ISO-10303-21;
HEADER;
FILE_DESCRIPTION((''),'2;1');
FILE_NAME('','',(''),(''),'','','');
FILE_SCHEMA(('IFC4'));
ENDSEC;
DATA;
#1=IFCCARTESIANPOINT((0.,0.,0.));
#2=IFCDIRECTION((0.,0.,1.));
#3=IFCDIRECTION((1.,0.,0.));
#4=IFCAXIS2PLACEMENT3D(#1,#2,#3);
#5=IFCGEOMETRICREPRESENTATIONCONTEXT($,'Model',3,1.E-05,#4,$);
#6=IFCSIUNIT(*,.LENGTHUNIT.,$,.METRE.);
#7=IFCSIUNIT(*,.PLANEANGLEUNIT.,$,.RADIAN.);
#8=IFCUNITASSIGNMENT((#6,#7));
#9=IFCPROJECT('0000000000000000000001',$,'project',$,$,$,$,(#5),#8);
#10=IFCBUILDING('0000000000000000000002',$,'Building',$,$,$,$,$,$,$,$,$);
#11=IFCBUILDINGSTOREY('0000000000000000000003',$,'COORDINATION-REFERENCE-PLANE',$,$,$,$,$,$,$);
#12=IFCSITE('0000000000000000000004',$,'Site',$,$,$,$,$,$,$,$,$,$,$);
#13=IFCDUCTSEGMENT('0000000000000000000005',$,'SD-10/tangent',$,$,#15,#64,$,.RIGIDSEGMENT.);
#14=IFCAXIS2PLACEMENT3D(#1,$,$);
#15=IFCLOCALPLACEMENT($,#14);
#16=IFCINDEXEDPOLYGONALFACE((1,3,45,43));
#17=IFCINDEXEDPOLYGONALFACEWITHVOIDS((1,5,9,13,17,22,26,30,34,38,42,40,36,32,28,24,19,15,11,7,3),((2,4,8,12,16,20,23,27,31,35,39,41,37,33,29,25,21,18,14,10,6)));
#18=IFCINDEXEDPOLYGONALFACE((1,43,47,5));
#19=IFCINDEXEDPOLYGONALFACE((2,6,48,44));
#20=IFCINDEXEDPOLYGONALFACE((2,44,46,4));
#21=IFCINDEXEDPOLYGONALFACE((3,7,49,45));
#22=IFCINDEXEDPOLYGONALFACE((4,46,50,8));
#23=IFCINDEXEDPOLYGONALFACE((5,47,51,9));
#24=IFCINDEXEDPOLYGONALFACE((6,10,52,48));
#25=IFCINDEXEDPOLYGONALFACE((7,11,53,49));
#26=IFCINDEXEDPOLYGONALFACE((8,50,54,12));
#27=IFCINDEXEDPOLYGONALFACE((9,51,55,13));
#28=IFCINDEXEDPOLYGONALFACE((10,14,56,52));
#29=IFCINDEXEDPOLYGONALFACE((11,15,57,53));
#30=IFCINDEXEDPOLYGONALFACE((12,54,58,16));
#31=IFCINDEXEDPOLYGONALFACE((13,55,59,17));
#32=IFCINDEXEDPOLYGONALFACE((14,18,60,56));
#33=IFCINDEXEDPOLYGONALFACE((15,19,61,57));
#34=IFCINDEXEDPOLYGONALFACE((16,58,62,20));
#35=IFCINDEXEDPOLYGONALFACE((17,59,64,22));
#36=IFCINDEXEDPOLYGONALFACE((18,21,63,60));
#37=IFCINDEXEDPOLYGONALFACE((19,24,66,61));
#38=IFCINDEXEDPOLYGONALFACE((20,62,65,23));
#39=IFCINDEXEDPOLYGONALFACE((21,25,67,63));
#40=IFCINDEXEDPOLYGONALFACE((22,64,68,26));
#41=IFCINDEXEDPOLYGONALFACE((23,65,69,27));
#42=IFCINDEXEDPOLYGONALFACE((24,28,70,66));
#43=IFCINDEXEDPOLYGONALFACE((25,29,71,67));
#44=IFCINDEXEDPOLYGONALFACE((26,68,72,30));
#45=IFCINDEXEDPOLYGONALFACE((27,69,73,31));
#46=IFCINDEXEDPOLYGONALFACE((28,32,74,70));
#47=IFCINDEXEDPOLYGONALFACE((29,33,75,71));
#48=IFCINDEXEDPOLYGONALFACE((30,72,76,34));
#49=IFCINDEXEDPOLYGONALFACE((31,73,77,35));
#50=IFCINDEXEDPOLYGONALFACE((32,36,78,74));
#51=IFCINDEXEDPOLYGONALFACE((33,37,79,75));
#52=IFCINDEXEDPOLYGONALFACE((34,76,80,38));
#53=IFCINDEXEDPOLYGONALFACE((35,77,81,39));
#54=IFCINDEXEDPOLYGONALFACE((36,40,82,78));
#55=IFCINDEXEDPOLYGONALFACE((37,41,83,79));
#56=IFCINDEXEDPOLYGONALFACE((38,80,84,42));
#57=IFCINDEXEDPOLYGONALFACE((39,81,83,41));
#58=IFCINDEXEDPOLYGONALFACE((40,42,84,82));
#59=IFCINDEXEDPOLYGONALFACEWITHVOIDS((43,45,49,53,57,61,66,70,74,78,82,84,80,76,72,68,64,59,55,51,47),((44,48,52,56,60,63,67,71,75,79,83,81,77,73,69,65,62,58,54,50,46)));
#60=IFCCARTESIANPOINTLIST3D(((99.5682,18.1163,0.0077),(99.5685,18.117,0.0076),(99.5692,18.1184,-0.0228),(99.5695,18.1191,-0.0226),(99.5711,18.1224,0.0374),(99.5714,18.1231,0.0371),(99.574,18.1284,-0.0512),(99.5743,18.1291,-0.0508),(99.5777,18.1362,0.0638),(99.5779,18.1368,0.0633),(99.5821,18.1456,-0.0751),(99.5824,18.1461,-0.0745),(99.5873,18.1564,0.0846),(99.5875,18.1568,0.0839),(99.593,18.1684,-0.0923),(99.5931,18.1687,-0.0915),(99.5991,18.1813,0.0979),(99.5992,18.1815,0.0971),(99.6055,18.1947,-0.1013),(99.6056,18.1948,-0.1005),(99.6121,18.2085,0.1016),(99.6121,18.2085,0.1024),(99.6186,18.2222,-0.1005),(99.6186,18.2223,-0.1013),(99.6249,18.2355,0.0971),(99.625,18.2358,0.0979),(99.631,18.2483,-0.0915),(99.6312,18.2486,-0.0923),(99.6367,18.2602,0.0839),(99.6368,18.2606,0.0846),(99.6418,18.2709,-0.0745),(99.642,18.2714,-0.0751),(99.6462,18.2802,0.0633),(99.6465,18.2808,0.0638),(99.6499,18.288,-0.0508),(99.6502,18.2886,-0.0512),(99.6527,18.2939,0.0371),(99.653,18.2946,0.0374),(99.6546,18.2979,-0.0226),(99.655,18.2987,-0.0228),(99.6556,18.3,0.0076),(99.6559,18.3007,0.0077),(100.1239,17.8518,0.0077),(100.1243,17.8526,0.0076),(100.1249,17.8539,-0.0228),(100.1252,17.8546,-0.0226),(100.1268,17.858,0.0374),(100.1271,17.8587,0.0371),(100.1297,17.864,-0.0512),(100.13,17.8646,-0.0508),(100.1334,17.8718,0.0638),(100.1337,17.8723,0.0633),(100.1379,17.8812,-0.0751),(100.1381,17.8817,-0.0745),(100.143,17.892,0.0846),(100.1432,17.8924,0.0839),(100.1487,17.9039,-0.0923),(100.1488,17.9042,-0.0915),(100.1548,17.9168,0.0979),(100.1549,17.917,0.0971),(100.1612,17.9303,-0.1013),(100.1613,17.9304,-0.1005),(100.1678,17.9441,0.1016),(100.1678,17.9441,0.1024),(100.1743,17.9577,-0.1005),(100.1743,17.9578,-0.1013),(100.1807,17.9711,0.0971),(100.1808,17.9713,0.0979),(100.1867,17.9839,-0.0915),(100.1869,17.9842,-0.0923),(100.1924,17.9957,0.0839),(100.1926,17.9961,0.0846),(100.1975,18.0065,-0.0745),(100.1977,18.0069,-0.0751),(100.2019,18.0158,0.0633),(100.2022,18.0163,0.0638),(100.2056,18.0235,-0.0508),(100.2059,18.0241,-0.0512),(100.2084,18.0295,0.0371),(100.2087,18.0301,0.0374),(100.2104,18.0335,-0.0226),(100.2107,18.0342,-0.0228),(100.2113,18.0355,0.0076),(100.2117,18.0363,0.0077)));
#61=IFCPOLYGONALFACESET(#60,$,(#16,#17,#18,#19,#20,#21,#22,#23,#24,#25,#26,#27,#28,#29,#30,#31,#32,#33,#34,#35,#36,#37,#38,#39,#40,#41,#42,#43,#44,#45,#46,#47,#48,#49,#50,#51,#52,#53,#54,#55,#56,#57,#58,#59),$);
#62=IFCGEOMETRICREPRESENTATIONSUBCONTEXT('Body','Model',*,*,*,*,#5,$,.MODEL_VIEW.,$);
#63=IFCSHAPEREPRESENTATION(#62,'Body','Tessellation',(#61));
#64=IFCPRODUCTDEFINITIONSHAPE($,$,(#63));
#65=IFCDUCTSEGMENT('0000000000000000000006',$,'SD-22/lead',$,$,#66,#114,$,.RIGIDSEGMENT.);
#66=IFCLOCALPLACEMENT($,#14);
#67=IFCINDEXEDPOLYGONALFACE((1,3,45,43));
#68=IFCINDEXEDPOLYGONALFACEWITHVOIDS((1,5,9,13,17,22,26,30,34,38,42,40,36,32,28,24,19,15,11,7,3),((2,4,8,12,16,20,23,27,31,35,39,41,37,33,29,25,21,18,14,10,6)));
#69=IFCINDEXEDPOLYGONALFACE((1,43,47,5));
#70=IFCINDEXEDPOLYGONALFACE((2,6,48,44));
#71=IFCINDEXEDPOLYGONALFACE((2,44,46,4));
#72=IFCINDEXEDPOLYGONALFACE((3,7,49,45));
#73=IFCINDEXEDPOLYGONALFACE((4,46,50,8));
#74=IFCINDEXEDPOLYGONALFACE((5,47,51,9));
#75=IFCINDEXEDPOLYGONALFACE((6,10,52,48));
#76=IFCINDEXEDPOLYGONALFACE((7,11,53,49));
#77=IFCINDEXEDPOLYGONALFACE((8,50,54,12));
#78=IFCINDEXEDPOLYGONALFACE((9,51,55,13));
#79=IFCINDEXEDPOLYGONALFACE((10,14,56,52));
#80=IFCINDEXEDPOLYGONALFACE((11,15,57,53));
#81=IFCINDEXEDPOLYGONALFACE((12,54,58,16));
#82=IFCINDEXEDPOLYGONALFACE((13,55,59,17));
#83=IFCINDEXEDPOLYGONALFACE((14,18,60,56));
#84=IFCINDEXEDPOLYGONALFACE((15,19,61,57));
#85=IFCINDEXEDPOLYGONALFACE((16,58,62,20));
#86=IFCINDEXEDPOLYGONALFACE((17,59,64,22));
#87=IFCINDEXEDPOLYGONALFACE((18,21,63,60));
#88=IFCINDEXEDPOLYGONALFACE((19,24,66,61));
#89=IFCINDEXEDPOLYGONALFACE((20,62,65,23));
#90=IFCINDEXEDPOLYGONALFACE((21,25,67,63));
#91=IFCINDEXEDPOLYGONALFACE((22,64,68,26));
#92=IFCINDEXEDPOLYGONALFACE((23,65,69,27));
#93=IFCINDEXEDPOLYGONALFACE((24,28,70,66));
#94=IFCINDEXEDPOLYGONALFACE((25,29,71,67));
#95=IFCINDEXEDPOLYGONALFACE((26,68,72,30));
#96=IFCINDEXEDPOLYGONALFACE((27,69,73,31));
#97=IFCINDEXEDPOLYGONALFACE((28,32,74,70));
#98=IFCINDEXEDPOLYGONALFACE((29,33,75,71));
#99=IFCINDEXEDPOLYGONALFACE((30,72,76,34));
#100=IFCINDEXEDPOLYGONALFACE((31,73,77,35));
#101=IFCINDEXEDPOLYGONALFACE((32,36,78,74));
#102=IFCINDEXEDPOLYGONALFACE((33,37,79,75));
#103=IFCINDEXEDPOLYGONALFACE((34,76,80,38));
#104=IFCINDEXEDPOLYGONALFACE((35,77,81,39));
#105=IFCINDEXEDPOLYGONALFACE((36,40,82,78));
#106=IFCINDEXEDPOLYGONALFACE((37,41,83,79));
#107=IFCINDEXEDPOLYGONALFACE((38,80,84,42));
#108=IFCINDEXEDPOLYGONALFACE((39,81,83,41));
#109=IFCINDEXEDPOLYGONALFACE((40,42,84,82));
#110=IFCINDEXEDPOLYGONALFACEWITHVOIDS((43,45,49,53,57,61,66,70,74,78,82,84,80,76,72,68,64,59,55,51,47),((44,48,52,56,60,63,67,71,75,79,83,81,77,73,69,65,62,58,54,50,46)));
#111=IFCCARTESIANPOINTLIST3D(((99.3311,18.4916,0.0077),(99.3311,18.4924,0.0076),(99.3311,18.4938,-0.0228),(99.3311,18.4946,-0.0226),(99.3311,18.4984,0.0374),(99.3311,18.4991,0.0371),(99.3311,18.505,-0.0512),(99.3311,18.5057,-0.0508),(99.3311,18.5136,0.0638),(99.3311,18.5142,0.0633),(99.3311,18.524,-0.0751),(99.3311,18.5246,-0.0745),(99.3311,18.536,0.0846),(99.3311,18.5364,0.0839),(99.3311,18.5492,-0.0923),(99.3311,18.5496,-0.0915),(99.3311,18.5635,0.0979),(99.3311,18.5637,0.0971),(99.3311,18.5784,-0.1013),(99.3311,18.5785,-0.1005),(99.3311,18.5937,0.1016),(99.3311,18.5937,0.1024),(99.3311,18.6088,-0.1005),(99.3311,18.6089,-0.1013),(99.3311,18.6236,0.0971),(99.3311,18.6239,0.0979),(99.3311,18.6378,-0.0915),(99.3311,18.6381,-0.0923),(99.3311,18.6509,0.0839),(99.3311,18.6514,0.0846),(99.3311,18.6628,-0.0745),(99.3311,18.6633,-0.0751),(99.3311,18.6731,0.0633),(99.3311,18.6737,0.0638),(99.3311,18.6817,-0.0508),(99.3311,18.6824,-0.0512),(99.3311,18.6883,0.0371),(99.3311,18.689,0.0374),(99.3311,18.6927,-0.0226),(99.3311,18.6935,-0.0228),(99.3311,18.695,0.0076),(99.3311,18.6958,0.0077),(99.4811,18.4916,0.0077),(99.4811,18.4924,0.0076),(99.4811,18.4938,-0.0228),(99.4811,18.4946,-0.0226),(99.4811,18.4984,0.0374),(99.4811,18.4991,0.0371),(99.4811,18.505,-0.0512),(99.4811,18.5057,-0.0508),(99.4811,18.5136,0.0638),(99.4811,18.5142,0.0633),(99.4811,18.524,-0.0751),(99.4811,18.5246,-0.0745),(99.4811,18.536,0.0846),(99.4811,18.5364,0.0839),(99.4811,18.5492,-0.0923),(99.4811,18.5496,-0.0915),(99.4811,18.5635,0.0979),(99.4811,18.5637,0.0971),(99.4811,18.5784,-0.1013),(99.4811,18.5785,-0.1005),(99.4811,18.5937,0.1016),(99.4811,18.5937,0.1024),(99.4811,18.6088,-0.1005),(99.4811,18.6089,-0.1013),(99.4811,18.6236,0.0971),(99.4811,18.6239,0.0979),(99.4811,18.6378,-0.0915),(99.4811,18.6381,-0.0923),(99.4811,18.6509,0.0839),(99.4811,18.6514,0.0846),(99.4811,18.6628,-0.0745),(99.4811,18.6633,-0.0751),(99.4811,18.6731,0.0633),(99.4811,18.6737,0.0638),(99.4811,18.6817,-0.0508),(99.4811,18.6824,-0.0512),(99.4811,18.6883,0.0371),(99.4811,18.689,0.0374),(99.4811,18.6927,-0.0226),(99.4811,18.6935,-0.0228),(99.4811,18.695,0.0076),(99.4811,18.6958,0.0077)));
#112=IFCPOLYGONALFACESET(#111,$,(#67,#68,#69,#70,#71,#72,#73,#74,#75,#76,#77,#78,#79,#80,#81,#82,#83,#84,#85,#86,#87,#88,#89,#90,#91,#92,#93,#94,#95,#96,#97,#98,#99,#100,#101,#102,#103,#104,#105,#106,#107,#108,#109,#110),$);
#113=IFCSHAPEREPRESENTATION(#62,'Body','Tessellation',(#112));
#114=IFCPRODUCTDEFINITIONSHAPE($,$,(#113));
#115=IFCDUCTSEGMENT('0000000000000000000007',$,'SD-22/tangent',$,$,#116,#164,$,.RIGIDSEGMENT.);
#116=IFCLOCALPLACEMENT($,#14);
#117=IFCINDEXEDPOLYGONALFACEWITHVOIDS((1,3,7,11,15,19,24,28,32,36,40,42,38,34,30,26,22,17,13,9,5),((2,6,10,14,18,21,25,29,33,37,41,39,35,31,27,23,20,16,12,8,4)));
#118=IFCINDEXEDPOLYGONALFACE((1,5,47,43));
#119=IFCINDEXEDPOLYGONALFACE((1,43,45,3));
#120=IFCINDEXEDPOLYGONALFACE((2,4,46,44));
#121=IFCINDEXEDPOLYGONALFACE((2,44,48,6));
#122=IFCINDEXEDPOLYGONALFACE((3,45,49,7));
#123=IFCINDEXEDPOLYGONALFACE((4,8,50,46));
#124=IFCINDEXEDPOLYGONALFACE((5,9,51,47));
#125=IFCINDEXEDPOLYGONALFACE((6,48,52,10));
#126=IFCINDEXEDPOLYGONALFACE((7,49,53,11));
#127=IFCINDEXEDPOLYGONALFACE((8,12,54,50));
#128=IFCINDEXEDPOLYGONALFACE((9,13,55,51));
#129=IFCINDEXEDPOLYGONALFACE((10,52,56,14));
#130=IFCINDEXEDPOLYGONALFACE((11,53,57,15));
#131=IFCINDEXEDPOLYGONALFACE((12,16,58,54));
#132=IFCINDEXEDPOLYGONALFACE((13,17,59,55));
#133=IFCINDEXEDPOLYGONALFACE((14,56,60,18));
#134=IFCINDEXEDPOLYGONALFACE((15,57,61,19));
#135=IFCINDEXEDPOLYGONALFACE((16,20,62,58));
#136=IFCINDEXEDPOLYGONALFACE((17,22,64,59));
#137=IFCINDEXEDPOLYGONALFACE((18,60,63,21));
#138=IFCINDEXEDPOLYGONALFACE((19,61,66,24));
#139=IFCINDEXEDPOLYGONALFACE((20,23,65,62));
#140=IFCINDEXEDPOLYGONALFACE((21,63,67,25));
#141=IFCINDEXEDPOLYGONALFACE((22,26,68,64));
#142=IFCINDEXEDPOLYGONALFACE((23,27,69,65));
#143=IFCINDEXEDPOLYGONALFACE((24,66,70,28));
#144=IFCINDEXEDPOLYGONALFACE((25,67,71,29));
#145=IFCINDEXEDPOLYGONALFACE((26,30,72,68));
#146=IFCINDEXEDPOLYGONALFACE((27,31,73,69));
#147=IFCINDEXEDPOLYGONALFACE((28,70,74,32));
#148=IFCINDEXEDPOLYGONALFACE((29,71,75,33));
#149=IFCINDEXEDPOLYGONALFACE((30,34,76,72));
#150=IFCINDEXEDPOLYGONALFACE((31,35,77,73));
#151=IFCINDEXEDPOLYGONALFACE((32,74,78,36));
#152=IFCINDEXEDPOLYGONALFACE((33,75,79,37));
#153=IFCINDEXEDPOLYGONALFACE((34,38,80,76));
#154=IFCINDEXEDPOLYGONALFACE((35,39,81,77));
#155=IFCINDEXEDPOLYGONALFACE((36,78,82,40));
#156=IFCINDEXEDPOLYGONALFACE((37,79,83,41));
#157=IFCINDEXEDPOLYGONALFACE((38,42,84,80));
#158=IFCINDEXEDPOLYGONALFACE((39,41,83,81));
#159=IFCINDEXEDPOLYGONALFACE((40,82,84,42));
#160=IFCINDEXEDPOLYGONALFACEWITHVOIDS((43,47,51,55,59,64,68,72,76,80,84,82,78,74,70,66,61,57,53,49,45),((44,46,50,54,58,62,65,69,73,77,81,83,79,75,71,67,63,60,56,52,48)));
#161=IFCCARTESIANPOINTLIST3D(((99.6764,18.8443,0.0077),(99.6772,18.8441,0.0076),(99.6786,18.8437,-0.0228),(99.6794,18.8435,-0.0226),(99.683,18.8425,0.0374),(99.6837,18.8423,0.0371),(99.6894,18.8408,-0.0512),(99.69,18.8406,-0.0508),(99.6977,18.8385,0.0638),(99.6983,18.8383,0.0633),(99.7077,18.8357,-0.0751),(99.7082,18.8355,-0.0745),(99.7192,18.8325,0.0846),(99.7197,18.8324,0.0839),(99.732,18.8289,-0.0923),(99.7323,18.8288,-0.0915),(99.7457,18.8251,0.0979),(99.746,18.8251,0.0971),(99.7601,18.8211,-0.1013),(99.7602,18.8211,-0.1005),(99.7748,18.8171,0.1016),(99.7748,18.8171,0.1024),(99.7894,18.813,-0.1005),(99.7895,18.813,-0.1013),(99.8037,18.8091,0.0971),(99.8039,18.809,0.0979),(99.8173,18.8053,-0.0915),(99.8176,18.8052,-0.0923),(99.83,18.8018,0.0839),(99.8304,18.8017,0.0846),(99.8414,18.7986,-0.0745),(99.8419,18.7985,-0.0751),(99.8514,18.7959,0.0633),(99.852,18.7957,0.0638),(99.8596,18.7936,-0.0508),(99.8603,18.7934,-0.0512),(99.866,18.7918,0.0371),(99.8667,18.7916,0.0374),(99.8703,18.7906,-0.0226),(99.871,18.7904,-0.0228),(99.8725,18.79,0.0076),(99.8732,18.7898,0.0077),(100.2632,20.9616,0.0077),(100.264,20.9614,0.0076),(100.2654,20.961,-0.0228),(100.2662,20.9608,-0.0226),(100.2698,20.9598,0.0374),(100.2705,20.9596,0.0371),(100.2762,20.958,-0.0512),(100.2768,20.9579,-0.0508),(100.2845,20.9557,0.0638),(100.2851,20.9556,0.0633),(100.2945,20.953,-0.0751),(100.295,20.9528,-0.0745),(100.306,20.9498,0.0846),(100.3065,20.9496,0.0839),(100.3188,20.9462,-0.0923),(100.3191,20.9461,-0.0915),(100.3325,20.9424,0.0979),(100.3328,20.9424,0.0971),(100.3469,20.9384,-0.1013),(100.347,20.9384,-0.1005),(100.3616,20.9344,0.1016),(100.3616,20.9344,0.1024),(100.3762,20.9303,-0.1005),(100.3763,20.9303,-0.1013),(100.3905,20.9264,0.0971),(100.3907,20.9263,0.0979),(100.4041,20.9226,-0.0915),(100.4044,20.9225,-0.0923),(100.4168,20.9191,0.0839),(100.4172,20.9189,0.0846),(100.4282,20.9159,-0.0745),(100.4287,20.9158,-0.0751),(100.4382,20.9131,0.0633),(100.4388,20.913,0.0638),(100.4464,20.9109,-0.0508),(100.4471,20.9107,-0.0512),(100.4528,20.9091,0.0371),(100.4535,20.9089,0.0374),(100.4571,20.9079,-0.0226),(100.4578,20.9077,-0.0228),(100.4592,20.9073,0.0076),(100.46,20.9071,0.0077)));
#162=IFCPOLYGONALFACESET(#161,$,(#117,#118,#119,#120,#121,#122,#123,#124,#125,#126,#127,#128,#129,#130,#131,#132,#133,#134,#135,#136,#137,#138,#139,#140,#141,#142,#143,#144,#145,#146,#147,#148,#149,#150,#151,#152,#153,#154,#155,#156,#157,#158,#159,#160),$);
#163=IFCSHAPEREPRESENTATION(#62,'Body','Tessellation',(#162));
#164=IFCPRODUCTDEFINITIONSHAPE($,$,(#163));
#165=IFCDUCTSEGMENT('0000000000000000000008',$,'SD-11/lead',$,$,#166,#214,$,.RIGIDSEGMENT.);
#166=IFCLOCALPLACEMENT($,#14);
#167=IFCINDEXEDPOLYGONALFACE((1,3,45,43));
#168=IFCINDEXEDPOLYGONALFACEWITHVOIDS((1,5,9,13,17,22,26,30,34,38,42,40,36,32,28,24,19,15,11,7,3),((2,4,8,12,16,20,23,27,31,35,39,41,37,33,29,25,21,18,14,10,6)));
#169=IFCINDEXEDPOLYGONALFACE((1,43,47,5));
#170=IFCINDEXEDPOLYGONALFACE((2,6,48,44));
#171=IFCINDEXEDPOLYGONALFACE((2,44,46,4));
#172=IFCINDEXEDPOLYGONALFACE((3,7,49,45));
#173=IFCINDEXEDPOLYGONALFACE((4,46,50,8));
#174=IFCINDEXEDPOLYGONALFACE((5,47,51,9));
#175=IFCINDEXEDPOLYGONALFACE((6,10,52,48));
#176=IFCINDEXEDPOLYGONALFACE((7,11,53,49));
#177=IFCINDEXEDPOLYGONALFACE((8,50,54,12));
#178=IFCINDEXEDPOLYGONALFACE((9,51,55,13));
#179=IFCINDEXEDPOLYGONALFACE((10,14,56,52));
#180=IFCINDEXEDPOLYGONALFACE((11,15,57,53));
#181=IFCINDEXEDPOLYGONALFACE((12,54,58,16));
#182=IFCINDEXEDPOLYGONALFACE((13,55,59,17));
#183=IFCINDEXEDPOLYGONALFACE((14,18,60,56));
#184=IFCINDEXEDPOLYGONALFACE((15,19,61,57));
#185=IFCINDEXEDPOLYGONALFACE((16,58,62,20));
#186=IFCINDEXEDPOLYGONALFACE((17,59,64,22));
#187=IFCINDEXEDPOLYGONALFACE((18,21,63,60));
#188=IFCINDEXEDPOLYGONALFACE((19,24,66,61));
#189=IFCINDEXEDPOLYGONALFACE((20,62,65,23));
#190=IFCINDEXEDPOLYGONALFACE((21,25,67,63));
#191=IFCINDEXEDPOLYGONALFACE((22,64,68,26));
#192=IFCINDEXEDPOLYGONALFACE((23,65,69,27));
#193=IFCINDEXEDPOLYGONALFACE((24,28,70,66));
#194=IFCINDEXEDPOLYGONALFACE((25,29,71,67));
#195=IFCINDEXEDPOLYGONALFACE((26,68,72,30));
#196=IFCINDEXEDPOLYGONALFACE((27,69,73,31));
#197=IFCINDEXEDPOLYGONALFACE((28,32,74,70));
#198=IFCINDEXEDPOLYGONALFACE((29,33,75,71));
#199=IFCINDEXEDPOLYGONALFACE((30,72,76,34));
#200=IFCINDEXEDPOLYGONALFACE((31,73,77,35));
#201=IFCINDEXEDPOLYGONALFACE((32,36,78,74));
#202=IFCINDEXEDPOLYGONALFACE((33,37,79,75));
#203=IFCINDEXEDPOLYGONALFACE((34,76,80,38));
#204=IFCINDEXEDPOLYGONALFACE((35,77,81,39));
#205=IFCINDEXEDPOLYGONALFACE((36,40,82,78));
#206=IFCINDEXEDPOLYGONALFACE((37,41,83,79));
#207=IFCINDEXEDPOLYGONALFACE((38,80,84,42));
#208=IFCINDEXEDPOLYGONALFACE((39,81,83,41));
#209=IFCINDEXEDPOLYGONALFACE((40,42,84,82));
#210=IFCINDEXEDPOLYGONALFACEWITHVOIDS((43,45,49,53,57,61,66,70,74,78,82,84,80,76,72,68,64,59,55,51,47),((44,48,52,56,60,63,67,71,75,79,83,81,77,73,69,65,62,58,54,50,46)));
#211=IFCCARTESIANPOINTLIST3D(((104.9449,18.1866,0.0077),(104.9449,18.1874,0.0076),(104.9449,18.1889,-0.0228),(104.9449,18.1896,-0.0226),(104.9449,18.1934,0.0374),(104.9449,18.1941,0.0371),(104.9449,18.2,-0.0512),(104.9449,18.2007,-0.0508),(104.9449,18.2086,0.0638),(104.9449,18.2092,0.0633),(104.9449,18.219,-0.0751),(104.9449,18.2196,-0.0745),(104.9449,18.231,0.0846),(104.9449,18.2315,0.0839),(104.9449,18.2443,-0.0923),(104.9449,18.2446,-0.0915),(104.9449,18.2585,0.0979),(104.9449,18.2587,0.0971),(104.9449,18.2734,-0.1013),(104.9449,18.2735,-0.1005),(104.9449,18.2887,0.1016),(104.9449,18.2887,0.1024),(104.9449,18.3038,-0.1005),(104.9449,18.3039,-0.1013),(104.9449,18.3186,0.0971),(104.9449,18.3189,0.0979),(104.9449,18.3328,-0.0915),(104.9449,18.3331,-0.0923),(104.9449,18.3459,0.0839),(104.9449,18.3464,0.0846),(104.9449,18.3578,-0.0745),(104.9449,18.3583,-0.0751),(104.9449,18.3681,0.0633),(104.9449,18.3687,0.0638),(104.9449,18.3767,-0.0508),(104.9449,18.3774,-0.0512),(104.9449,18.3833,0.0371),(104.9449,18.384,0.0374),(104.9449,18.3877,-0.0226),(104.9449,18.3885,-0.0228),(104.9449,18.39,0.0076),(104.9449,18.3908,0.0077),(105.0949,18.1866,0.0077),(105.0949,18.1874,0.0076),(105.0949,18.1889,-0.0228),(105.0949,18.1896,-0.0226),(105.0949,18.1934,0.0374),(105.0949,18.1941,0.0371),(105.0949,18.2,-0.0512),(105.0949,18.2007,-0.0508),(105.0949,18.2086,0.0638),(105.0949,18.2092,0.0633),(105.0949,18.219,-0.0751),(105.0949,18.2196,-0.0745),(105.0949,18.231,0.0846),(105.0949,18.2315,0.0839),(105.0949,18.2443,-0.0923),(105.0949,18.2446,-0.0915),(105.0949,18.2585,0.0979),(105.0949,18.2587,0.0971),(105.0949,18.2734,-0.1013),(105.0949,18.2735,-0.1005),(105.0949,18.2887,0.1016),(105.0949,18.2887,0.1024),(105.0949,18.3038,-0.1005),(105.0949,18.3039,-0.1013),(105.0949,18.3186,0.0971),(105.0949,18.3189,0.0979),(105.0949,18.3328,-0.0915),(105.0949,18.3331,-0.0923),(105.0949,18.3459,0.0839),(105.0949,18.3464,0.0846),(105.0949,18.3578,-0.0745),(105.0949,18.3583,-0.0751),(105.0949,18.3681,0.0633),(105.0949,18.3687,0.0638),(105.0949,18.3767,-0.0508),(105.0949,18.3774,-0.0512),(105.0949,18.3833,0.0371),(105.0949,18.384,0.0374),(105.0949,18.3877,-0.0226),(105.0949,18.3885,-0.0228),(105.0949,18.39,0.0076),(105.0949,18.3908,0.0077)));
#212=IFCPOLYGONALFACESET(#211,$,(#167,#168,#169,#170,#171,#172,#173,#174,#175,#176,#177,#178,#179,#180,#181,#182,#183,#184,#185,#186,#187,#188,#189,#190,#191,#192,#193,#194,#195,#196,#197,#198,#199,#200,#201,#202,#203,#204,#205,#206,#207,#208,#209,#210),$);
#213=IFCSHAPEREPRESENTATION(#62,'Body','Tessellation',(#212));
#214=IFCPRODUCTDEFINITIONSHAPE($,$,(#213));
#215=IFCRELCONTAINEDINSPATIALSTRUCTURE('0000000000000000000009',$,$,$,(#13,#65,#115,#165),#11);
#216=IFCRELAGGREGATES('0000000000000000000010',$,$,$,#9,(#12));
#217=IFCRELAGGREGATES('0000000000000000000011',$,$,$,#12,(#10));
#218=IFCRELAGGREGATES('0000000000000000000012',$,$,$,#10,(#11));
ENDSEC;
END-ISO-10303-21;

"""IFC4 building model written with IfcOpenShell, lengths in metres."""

from ifc_helpers import new_model, si_unit, frame, origin_with_axes, place, context, subcontext, project, spatial, hollow_circle, extrude, element, save


model = new_model("IFC4")

# Units and contexts
model_context = context("Model", 3, precision=1e-05, world=origin_with_axes())
body_context_1 = subcontext(model_context, "Body", "Model", "MODEL_VIEW")
ifc_project = project(units=[si_unit("LENGTHUNIT", "METRE"), si_unit("PLANEANGLEUNIT", "RADIAN")], contexts=[model_context])

# Site, building, storey
site = spatial("IfcSite", under=ifc_project, Name="Site")
building = spatial("IfcBuilding", under=site, Name="Building")
storey = spatial("IfcBuildingStorey", under=building, Name="COORDINATION-REFERENCE-PLANE")

# Duct segment
duct_segment_1_placement = place(None, frame((99.6121, 18.2085, 0.0), z_axis=(0.902975, -0.429693, 0.0), x_axis=(0.0, 0.0, 1.0)))
element("IfcDuctSegment", 1, at=duct_segment_1_placement, inside=storey, Name="SD-10/tangent", PredefinedType="RIGIDSEGMENT", context=body_context_1, shape_type="SweptSolid", body=[
    extrude(hollow_circle(Radius=0.1024, WallThickness=0.0008), origin_with_axes(), (0.0, 0.0, 1.0), 0.6154),
])

# Duct segment
duct_segment_2_placement = place(None, frame((99.3311, 18.5937, 0.0), z_axis=(1.0, 0.0, 0.0), x_axis=(0.0, 0.0, 1.0)))
element("IfcDuctSegment", 2, at=duct_segment_2_placement, inside=storey, Name="SD-22/lead", PredefinedType="RIGIDSEGMENT", context=body_context_1, shape_type="SweptSolid", body=[
    extrude(hollow_circle(Radius=0.1024, WallThickness=0.0008), origin_with_axes(), (0.0, 0.0, 1.0), 0.15),
])

# Duct segment
duct_segment_3_placement = place(None, frame((99.7748, 18.8171, 0.0), z_axis=(0.267077, 0.963675, 0.0), x_axis=(0.0, 0.0, 1.0)))
element("IfcDuctSegment", 3, at=duct_segment_3_placement, inside=storey, Name="SD-22/tangent", PredefinedType="RIGIDSEGMENT", context=body_context_1, shape_type="SweptSolid", body=[
    extrude(hollow_circle(Radius=0.1024, WallThickness=0.0008), origin_with_axes(), (0.0, 0.0, 1.0), 2.1971),
])

# Duct segment
duct_segment_4_placement = place(None, frame((105.0949, 18.2887, 0.0), z_axis=(-1.0, 0.0, 0.0), x_axis=(0.0, 0.0, 1.0)))
element("IfcDuctSegment", 4, at=duct_segment_4_placement, inside=storey, Name="SD-11/lead", PredefinedType="RIGIDSEGMENT", context=body_context_1, shape_type="SweptSolid", body=[
    extrude(hollow_circle(Radius=0.1024, WallThickness=0.0008), origin_with_axes(), (0.0, 0.0, 1.0), 0.15),
])

save(model, "model.ifc")
